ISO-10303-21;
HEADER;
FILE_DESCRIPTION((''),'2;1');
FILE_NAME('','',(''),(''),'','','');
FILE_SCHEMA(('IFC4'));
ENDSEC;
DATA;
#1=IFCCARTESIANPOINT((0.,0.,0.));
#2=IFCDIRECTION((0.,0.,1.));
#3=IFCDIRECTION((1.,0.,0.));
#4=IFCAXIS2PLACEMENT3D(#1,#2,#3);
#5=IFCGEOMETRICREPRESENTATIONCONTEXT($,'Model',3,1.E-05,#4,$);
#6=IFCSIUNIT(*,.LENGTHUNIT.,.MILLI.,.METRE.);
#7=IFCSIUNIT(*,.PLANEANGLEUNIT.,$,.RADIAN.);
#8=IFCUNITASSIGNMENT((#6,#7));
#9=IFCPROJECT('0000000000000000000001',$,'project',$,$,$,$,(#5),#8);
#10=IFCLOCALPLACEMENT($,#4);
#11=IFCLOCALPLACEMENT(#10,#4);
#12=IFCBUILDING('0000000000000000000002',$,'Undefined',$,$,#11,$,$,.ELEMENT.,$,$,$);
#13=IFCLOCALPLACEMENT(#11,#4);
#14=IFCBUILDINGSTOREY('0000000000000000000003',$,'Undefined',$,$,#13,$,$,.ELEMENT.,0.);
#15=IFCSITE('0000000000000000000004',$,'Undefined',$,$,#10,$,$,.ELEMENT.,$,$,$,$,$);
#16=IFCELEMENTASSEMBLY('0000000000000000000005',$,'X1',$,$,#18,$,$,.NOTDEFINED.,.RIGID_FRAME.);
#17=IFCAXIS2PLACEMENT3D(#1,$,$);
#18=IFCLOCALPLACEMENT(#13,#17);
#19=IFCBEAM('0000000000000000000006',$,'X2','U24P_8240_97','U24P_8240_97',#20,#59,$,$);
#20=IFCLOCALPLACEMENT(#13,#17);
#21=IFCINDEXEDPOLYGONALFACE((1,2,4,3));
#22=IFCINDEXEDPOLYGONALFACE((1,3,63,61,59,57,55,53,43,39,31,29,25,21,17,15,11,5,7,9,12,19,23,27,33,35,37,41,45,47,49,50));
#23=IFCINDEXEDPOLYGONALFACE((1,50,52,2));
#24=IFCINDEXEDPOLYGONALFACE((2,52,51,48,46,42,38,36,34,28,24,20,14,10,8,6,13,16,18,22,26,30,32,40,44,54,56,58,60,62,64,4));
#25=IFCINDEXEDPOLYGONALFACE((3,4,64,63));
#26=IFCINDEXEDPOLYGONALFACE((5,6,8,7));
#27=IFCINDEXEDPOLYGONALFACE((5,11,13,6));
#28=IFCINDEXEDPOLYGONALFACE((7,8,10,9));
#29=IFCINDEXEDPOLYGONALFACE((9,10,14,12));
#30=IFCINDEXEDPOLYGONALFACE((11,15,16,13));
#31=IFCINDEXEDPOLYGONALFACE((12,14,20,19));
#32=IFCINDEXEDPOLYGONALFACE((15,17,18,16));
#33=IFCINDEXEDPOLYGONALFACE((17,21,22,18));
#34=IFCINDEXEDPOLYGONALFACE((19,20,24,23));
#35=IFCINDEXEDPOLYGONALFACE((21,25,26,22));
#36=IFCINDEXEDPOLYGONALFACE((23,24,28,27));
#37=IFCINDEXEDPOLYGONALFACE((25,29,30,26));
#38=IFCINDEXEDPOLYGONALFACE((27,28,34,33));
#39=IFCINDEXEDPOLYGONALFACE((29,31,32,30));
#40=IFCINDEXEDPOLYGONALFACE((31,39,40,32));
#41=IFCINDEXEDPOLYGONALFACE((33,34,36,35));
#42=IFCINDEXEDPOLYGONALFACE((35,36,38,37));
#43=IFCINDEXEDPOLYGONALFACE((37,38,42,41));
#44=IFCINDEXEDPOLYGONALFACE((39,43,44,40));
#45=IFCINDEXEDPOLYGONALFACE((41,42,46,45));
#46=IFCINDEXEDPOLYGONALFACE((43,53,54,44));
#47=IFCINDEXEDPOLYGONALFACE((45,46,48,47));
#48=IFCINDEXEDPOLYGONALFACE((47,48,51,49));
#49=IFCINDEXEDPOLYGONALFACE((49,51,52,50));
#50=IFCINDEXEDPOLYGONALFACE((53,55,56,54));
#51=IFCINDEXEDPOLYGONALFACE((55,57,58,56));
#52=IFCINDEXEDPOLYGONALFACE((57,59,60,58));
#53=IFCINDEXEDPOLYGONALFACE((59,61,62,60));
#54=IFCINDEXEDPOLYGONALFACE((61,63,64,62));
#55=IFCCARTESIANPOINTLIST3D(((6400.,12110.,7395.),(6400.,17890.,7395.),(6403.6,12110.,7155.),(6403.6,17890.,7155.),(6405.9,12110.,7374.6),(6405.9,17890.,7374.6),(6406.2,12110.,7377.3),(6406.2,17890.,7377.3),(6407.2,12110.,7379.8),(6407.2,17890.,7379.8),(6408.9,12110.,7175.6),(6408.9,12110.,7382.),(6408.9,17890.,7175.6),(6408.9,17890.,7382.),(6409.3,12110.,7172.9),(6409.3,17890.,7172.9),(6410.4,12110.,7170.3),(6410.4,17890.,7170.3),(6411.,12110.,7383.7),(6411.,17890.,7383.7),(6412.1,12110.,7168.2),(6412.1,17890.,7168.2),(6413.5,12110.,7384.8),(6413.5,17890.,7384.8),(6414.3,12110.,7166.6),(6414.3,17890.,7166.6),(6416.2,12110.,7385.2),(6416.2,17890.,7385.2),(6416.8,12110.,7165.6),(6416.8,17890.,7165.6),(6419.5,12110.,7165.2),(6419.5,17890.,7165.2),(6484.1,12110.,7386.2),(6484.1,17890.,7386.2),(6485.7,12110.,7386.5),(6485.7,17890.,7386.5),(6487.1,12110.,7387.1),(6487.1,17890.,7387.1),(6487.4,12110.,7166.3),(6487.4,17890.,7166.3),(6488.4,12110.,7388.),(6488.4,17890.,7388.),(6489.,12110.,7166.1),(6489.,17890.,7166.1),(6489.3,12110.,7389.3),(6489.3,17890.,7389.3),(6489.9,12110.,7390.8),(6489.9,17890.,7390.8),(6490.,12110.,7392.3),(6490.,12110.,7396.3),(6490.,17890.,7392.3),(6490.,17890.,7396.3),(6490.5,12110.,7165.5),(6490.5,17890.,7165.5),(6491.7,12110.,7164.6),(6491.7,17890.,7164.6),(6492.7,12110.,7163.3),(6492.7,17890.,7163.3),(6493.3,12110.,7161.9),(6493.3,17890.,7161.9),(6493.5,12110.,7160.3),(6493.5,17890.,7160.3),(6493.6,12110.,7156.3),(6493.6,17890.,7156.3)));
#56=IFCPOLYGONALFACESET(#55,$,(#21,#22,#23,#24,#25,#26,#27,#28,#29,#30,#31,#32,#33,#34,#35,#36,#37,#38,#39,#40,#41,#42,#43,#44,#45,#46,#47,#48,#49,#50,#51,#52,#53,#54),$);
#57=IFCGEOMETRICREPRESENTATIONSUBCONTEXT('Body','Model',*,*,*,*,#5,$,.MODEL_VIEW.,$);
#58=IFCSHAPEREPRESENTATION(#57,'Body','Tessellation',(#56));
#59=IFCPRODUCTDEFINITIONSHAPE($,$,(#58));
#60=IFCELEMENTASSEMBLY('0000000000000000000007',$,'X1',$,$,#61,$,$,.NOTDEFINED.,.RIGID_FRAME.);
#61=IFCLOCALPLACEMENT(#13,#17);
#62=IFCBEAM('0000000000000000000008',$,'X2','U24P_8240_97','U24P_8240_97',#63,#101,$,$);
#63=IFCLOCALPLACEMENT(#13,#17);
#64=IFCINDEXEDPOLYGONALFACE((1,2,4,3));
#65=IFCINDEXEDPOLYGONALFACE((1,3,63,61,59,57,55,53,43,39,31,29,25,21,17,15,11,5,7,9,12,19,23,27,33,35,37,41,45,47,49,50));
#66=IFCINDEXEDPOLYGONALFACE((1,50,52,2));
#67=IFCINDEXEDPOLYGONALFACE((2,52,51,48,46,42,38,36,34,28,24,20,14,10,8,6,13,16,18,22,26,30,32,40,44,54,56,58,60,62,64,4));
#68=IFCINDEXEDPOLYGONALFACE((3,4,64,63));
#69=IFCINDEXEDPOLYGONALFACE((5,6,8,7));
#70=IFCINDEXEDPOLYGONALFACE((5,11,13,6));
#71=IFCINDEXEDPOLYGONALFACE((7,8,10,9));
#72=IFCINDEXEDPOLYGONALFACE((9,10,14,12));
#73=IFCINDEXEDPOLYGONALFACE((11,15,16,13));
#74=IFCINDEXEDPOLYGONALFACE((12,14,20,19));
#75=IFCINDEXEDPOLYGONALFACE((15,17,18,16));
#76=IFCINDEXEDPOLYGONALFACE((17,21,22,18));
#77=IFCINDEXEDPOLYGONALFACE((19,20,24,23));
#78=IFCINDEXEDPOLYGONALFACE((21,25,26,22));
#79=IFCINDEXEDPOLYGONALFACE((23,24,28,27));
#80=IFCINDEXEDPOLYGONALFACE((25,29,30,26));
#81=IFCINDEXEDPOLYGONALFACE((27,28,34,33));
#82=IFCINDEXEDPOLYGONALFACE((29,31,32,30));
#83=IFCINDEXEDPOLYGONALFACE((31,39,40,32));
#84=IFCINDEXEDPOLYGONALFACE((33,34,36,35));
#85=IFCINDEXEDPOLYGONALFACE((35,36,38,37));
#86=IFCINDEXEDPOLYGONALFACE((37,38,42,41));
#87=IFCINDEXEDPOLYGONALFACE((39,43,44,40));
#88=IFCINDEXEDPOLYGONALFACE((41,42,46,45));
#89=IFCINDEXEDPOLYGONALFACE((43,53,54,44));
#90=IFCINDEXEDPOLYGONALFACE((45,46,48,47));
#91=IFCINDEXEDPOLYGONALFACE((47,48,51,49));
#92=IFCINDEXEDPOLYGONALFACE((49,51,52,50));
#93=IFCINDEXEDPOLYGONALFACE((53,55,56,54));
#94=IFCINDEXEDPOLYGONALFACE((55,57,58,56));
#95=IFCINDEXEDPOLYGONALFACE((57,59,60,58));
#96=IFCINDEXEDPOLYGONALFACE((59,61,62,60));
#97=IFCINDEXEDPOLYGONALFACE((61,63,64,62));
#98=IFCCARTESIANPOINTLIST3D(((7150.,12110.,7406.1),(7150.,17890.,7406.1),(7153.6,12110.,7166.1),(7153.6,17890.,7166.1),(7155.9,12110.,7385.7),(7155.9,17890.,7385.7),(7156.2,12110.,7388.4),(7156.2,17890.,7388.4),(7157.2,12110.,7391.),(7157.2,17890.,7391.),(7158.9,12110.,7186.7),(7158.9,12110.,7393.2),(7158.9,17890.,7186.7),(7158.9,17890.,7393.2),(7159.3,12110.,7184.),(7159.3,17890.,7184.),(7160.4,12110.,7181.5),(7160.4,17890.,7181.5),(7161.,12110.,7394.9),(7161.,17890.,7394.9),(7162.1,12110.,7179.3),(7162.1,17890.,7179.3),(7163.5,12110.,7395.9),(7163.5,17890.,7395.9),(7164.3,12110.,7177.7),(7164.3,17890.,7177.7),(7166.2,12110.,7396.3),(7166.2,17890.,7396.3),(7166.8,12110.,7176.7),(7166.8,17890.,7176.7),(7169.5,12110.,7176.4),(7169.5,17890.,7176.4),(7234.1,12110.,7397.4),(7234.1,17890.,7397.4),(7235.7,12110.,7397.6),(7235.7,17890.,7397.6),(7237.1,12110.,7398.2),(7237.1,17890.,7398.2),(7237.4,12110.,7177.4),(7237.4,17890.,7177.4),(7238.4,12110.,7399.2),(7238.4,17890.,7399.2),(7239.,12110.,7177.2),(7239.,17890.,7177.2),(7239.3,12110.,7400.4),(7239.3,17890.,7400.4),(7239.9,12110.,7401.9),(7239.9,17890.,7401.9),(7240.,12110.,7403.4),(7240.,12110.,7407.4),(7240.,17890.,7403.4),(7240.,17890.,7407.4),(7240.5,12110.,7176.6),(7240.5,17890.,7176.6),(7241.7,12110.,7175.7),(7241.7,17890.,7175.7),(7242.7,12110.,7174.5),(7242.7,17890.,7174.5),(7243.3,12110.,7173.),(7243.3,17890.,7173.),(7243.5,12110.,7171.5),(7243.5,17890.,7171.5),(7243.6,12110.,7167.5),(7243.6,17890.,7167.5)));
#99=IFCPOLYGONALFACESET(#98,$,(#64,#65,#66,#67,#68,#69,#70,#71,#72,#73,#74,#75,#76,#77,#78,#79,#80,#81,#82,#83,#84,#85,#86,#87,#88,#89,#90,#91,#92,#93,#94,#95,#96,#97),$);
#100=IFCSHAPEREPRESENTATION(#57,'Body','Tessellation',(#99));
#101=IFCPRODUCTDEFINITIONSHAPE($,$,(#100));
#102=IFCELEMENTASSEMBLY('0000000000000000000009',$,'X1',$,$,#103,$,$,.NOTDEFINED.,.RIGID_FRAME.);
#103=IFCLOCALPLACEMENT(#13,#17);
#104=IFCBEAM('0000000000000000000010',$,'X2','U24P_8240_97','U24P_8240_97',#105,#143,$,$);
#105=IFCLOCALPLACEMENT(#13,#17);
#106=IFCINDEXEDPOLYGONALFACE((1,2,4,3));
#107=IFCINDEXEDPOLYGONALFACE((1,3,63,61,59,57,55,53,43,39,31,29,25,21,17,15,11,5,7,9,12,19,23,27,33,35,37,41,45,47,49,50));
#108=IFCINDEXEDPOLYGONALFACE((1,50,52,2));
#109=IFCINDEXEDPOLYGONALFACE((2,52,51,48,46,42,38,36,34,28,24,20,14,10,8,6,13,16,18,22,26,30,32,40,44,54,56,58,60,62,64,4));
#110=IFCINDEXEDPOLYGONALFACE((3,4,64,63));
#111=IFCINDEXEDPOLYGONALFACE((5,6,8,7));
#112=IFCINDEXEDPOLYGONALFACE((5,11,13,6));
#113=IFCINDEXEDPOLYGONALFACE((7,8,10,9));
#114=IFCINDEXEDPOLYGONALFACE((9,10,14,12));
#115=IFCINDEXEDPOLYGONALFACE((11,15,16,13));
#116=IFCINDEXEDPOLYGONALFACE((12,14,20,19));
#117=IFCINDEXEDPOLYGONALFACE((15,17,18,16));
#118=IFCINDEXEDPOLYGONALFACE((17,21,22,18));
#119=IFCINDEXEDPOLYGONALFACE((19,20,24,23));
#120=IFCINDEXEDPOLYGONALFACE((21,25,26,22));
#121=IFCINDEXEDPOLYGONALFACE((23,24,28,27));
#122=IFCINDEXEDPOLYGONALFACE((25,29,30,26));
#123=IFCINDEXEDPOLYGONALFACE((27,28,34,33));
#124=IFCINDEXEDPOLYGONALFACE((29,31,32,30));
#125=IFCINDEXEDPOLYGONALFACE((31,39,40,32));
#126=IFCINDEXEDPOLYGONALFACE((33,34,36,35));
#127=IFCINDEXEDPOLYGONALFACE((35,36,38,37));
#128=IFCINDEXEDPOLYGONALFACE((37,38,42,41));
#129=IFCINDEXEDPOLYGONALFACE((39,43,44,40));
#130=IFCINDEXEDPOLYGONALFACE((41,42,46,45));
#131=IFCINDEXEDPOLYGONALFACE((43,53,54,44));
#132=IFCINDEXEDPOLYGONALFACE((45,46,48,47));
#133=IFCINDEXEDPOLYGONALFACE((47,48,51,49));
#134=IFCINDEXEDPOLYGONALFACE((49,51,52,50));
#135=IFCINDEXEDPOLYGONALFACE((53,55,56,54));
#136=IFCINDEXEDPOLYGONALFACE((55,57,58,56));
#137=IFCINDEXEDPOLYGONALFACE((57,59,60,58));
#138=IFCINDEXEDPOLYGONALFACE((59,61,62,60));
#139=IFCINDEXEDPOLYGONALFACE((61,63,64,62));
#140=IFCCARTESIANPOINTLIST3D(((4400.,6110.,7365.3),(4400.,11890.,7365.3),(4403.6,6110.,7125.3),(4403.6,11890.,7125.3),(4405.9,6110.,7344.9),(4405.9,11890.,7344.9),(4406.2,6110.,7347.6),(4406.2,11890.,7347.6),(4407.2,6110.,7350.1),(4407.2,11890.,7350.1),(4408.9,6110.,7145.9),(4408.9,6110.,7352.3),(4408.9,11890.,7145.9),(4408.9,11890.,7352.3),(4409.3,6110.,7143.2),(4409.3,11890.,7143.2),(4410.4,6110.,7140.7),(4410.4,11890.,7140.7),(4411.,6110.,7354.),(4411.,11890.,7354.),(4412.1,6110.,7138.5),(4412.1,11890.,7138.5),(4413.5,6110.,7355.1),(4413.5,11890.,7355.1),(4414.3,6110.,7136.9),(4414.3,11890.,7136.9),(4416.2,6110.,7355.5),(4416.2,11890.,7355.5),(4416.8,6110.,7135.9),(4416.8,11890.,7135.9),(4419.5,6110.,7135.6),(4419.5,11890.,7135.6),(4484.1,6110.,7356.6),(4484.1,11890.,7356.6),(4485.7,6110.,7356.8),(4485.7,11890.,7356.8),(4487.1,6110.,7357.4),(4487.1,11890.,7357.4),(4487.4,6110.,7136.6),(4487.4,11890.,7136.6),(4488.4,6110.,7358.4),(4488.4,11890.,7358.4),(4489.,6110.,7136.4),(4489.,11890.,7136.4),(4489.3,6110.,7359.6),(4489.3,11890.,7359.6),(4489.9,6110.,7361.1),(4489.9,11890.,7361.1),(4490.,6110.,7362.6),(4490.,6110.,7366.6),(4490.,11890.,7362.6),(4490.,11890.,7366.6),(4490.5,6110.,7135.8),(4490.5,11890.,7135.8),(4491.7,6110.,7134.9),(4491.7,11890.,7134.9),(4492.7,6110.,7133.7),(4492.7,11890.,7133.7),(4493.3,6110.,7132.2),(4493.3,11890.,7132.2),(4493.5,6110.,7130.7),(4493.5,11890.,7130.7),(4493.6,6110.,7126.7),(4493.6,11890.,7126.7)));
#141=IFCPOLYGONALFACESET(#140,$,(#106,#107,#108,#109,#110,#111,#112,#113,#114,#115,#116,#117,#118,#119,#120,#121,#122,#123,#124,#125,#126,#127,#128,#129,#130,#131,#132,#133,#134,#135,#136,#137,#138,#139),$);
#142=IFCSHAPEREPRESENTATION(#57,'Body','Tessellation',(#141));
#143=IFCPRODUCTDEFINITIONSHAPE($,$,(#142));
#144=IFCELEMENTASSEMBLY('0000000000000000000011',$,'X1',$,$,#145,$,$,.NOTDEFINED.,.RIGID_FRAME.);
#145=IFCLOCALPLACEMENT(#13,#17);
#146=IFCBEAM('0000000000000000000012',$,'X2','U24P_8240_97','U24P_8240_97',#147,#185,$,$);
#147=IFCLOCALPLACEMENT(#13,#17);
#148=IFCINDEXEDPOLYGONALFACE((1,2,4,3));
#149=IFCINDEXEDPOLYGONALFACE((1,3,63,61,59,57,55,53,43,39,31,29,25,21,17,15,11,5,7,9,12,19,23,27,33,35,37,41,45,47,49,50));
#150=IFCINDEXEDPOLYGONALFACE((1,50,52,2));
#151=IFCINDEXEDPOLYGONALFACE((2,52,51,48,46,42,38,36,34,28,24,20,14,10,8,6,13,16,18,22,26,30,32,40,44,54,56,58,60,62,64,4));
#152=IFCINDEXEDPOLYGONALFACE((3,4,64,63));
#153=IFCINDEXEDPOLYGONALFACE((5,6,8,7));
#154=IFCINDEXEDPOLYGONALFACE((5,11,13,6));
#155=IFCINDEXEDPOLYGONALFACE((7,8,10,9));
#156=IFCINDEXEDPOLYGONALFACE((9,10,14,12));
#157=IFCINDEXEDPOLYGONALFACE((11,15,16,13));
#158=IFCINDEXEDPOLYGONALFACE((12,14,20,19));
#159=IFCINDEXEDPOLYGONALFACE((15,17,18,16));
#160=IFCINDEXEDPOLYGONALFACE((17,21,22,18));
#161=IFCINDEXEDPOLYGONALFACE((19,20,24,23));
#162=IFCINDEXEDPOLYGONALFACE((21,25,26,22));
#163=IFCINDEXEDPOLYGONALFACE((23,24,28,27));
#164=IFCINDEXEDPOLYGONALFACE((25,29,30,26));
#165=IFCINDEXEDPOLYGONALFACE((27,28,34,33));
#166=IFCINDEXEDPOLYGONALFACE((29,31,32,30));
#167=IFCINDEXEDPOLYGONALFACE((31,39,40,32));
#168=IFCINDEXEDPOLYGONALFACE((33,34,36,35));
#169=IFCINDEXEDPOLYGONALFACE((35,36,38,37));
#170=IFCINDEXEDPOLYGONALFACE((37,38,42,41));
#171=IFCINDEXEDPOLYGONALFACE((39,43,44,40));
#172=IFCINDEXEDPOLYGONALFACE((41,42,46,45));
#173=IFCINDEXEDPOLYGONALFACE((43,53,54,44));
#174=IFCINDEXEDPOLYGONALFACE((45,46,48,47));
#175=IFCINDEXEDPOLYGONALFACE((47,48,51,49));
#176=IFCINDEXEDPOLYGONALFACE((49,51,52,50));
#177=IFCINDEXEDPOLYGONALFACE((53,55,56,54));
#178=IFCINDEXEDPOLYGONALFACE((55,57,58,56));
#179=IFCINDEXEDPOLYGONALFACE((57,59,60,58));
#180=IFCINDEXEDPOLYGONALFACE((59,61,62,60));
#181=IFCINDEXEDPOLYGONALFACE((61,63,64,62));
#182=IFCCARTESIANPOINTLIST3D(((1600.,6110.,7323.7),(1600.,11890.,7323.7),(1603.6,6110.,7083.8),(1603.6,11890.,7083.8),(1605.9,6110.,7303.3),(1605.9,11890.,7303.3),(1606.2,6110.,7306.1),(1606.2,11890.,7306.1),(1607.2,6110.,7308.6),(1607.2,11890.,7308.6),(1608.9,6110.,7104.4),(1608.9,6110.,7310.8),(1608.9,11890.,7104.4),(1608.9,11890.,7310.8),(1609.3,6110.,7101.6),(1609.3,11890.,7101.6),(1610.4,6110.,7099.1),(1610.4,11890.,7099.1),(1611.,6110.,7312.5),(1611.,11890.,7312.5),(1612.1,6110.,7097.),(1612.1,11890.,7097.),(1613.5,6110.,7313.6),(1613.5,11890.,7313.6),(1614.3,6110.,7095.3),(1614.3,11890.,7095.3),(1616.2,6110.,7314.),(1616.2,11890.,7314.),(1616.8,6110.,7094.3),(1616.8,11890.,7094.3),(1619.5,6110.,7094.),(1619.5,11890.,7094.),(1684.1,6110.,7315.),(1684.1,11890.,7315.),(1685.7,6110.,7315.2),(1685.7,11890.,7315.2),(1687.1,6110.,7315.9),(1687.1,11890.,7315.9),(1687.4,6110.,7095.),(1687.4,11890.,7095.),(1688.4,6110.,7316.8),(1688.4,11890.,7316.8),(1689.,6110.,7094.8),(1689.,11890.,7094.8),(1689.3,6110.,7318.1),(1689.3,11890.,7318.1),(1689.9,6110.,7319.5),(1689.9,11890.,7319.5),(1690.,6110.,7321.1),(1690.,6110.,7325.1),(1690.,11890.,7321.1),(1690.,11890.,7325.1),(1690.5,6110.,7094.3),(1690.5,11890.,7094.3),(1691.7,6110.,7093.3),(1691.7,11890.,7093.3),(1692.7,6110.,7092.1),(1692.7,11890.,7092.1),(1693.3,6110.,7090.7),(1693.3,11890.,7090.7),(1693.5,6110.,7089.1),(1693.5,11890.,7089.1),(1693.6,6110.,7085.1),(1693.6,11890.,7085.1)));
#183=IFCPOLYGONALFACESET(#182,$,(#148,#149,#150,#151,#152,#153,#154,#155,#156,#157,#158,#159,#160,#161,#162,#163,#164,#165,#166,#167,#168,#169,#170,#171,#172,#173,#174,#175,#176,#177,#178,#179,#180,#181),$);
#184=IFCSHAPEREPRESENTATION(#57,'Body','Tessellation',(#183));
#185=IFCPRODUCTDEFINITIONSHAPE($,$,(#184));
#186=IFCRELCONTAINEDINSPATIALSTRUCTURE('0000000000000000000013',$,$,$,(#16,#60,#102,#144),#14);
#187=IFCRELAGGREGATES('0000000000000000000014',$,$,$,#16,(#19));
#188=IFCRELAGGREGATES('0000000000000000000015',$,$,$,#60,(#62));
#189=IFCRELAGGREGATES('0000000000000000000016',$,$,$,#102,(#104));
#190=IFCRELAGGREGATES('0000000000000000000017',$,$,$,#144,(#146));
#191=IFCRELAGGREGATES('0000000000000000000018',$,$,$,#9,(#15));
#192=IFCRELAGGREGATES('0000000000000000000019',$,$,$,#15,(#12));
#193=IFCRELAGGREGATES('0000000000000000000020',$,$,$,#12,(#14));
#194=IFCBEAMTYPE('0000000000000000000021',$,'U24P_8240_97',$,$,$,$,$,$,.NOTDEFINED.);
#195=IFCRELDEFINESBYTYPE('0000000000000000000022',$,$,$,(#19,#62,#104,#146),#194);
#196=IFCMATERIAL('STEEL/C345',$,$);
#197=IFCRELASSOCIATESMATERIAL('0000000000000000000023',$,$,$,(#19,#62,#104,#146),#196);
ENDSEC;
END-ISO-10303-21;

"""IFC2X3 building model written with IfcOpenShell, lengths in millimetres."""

from ifc_helpers import new_model, si_unit, frame, origin_with_axes, origin_2d_with_axis, place, context, subcontext, project, spatial, u_section, extrude, material, type_object, element, aggregate, save


model = new_model("IFC2X3")

# Units and contexts
model_context = context("Model", 3, precision=1e-05, world=origin_with_axes())
body_context = subcontext(model_context, "Body", "Model", "MODEL_VIEW")
ifc_project = project(units=[si_unit("LENGTHUNIT", "METRE", prefix="MILLI"), si_unit("PLANEANGLEUNIT", "RADIAN")], contexts=[model_context])

# Site, building, storey
site_placement = place(None, origin_with_axes())
site = spatial("IfcSite", under=ifc_project, at=site_placement, Name="Undefined", CompositionType="ELEMENT")
building_placement = place(site_placement, origin_with_axes())
building = spatial("IfcBuilding", under=site, at=building_placement, Name="Undefined", CompositionType="ELEMENT")
storey_placement = place(building_placement, origin_with_axes())
storey = spatial("IfcBuildingStorey", under=building, at=storey_placement, Name="Undefined", CompositionType="ELEMENT", Elevation=0.0)

# Element assemblies, beams
ifc_material_1 = material(Name="STEEL/C345")
beam_type_1 = type_object("IfcBeamType", Name="U24P_8240_97", PredefinedType="NOTDEFINED")
assembly_1_placement = place(storey_placement, origin_with_axes())
assembly_1 = element("IfcElementAssembly", 1, at=assembly_1_placement, inside=storey, Name="X1", AssemblyPlace="NOTDEFINED", PredefinedType="RIGID_FRAME")
beam_1_placement = place(assembly_1_placement, frame((6446.8, 17890.0, 7275.7), z_axis=(0.014998, 0.0, -0.999888), x_axis=(0.0, -1.0, 0.0)))
beam_1 = element("IfcBeam", 2, at=beam_1_placement, type_object=beam_type_1, material=ifc_material_1, Name="X2", Description="U24P_8240_97", ObjectType="U24P_8240_97", context=body_context, shape_type="SweptSolid", body=[
    extrude(u_section(Depth=240.0, FlangeWidth=90.0, WebThickness=5.6, FlangeThickness=10.0, FilletRadius=10.5, EdgeRadius=6.0, at=origin_2d_with_axis()), frame((5780.0, 0.0, 0.0), z_axis=(-1.0, 0.0, 0.0), x_axis=(0.0, -1.0, 0.0)), (0.0, 0.0, 1.0), 5780.0),
])
aggregate(assembly_1, [beam_1])
assembly_2_placement = place(storey_placement, origin_with_axes())
assembly_2 = element("IfcElementAssembly", 3, at=assembly_2_placement, inside=storey, Name="X1", AssemblyPlace="NOTDEFINED", PredefinedType="RIGID_FRAME")
beam_2_placement = place(assembly_2_placement, frame((7196.8, 17890.0, 7286.8), z_axis=(0.014998, 0.0, -0.999888), x_axis=(0.0, -1.0, 0.0)))
beam_2 = element("IfcBeam", 4, at=beam_2_placement, type_object=beam_type_1, material=ifc_material_1, Name="X2", Description="U24P_8240_97", ObjectType="U24P_8240_97", context=body_context, shape_type="SweptSolid", body=[
    extrude(u_section(Depth=240.0, FlangeWidth=90.0, WebThickness=5.6, FlangeThickness=10.0, FilletRadius=10.5, EdgeRadius=6.0, at=origin_2d_with_axis()), frame((5780.0, 0.0, 0.0), z_axis=(-1.0, 0.0, 0.0), x_axis=(0.0, -1.0, 0.0)), (0.0, 0.0, 1.0), 5780.0),
])
aggregate(assembly_2, [beam_2])
assembly_3_placement = place(storey_placement, origin_with_axes())
assembly_3 = element("IfcElementAssembly", 5, at=assembly_3_placement, inside=storey, Name="X1", AssemblyPlace="NOTDEFINED", PredefinedType="RIGID_FRAME")
beam_3_placement = place(assembly_3_placement, frame((4446.8, 11890.0, 7246.0), z_axis=(0.014998, 0.0, -0.999888), x_axis=(0.0, -1.0, 0.0)))
beam_3 = element("IfcBeam", 6, at=beam_3_placement, type_object=beam_type_1, material=ifc_material_1, Name="X2", Description="U24P_8240_97", ObjectType="U24P_8240_97", context=body_context, shape_type="SweptSolid", body=[
    extrude(u_section(Depth=240.0, FlangeWidth=90.0, WebThickness=5.6, FlangeThickness=10.0, FilletRadius=10.5, EdgeRadius=6.0, at=origin_2d_with_axis()), frame((5780.0, 0.0, 0.0), z_axis=(-1.0, 0.0, 0.0), x_axis=(0.0, -1.0, 0.0)), (0.0, 0.0, 1.0), 5780.0),
])
aggregate(assembly_3, [beam_3])
assembly_4_placement = place(storey_placement, origin_with_axes())
assembly_4 = element("IfcElementAssembly", 7, at=assembly_4_placement, inside=storey, Name="X1", AssemblyPlace="NOTDEFINED", PredefinedType="RIGID_FRAME")
beam_4_placement = place(assembly_4_placement, frame((1646.8, 11890.0, 7204.4), z_axis=(0.014998, 0.0, -0.999888), x_axis=(0.0, -1.0, 0.0)))
beam_4 = element("IfcBeam", 8, at=beam_4_placement, type_object=beam_type_1, material=ifc_material_1, Name="X2", Description="U24P_8240_97", ObjectType="U24P_8240_97", context=body_context, shape_type="SweptSolid", body=[
    extrude(u_section(Depth=240.0, FlangeWidth=90.0, WebThickness=5.6, FlangeThickness=10.0, FilletRadius=10.5, EdgeRadius=6.0, at=origin_2d_with_axis()), frame((5780.0, 0.0, 0.0), z_axis=(-1.0, 0.0, 0.0), x_axis=(0.0, -1.0, 0.0)), (0.0, 0.0, 1.0), 5780.0),
])
aggregate(assembly_4, [beam_4])

save(model, "model.ifc")
